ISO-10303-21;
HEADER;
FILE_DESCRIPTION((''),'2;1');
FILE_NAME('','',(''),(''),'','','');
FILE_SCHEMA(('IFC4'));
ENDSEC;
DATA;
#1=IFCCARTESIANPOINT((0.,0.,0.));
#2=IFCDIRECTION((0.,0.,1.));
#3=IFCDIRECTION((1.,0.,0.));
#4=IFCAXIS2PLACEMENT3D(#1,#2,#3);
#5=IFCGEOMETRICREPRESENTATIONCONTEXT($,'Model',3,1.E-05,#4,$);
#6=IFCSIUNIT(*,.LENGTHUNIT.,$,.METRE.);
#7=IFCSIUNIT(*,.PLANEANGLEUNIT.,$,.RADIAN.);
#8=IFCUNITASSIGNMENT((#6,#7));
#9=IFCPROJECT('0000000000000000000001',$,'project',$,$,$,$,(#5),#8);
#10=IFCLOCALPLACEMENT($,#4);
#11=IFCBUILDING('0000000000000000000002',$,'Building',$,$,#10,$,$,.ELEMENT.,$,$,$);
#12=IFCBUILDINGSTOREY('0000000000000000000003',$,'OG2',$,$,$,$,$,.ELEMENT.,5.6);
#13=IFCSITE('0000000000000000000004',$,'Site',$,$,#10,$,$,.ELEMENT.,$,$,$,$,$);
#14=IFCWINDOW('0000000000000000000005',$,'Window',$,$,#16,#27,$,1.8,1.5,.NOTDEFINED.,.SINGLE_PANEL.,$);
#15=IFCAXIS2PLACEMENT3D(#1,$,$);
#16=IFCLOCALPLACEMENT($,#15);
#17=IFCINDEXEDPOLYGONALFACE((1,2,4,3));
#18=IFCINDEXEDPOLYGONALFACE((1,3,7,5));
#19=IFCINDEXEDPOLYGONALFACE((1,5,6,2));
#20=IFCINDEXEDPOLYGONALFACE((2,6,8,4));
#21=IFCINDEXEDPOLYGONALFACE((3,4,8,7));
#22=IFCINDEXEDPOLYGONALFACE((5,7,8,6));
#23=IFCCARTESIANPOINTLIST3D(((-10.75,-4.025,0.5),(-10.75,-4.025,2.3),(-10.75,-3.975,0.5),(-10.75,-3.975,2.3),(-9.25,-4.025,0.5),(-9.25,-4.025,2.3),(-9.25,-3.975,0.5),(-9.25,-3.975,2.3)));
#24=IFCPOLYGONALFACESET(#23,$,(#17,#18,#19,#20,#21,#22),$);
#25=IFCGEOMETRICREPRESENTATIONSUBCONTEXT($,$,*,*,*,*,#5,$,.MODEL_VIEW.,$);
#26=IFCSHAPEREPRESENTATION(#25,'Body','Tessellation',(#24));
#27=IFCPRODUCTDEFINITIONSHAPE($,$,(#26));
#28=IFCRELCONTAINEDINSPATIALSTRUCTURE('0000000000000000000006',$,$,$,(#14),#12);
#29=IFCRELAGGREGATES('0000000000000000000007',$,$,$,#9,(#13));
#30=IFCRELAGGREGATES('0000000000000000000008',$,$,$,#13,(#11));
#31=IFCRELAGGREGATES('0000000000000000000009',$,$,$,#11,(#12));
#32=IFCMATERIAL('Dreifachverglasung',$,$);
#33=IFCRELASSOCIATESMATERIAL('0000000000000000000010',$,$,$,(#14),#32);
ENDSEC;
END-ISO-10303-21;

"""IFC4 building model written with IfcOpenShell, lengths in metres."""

from ifc_helpers import new_model, si_unit, frame, origin, origin_with_axes, origin_2d, place, context, subcontext, project, spatial, rectangle, extrude, material, element, save


model = new_model("IFC4")

# Units and contexts
model_context = context("Model", 3, precision=1e-05, world=origin_with_axes())
sub_context = subcontext(model_context, None, None, "MODEL_VIEW")
ifc_project = project(units=[si_unit("LENGTHUNIT", "METRE"), si_unit("PLANEANGLEUNIT", "RADIAN")], contexts=[model_context])

# Site, building, storey
placement_1 = place(None, origin_with_axes())
site = spatial("IfcSite", under=ifc_project, at=placement_1, Name="Site", CompositionType="ELEMENT")
building = spatial("IfcBuilding", under=site, at=placement_1, Name="Building", CompositionType="ELEMENT")
storey = spatial("IfcBuildingStorey", under=building, Name="OG2", CompositionType="ELEMENT", Elevation=5.6)

# Window
ifc_material = material(Name="Dreifachverglasung")
placement_2 = place(None, origin_with_axes())
window_placement = place(placement_2, frame((-10.0, -4.0, 0.5)))
element("IfcWindow", 1, at=window_placement, inside=storey, material=ifc_material, Name="Window", OverallHeight=1.8, OverallWidth=1.5, PartitioningType="SINGLE_PANEL", PredefinedType="NOTDEFINED", context=sub_context, shape_type="SweptSolid", body=[
    extrude(rectangle(XDim=1.5, YDim=0.05, at=origin_2d()), origin(), (0.0, 0.0, 1.0), 1.8),
])

save(model, "model.ifc")
